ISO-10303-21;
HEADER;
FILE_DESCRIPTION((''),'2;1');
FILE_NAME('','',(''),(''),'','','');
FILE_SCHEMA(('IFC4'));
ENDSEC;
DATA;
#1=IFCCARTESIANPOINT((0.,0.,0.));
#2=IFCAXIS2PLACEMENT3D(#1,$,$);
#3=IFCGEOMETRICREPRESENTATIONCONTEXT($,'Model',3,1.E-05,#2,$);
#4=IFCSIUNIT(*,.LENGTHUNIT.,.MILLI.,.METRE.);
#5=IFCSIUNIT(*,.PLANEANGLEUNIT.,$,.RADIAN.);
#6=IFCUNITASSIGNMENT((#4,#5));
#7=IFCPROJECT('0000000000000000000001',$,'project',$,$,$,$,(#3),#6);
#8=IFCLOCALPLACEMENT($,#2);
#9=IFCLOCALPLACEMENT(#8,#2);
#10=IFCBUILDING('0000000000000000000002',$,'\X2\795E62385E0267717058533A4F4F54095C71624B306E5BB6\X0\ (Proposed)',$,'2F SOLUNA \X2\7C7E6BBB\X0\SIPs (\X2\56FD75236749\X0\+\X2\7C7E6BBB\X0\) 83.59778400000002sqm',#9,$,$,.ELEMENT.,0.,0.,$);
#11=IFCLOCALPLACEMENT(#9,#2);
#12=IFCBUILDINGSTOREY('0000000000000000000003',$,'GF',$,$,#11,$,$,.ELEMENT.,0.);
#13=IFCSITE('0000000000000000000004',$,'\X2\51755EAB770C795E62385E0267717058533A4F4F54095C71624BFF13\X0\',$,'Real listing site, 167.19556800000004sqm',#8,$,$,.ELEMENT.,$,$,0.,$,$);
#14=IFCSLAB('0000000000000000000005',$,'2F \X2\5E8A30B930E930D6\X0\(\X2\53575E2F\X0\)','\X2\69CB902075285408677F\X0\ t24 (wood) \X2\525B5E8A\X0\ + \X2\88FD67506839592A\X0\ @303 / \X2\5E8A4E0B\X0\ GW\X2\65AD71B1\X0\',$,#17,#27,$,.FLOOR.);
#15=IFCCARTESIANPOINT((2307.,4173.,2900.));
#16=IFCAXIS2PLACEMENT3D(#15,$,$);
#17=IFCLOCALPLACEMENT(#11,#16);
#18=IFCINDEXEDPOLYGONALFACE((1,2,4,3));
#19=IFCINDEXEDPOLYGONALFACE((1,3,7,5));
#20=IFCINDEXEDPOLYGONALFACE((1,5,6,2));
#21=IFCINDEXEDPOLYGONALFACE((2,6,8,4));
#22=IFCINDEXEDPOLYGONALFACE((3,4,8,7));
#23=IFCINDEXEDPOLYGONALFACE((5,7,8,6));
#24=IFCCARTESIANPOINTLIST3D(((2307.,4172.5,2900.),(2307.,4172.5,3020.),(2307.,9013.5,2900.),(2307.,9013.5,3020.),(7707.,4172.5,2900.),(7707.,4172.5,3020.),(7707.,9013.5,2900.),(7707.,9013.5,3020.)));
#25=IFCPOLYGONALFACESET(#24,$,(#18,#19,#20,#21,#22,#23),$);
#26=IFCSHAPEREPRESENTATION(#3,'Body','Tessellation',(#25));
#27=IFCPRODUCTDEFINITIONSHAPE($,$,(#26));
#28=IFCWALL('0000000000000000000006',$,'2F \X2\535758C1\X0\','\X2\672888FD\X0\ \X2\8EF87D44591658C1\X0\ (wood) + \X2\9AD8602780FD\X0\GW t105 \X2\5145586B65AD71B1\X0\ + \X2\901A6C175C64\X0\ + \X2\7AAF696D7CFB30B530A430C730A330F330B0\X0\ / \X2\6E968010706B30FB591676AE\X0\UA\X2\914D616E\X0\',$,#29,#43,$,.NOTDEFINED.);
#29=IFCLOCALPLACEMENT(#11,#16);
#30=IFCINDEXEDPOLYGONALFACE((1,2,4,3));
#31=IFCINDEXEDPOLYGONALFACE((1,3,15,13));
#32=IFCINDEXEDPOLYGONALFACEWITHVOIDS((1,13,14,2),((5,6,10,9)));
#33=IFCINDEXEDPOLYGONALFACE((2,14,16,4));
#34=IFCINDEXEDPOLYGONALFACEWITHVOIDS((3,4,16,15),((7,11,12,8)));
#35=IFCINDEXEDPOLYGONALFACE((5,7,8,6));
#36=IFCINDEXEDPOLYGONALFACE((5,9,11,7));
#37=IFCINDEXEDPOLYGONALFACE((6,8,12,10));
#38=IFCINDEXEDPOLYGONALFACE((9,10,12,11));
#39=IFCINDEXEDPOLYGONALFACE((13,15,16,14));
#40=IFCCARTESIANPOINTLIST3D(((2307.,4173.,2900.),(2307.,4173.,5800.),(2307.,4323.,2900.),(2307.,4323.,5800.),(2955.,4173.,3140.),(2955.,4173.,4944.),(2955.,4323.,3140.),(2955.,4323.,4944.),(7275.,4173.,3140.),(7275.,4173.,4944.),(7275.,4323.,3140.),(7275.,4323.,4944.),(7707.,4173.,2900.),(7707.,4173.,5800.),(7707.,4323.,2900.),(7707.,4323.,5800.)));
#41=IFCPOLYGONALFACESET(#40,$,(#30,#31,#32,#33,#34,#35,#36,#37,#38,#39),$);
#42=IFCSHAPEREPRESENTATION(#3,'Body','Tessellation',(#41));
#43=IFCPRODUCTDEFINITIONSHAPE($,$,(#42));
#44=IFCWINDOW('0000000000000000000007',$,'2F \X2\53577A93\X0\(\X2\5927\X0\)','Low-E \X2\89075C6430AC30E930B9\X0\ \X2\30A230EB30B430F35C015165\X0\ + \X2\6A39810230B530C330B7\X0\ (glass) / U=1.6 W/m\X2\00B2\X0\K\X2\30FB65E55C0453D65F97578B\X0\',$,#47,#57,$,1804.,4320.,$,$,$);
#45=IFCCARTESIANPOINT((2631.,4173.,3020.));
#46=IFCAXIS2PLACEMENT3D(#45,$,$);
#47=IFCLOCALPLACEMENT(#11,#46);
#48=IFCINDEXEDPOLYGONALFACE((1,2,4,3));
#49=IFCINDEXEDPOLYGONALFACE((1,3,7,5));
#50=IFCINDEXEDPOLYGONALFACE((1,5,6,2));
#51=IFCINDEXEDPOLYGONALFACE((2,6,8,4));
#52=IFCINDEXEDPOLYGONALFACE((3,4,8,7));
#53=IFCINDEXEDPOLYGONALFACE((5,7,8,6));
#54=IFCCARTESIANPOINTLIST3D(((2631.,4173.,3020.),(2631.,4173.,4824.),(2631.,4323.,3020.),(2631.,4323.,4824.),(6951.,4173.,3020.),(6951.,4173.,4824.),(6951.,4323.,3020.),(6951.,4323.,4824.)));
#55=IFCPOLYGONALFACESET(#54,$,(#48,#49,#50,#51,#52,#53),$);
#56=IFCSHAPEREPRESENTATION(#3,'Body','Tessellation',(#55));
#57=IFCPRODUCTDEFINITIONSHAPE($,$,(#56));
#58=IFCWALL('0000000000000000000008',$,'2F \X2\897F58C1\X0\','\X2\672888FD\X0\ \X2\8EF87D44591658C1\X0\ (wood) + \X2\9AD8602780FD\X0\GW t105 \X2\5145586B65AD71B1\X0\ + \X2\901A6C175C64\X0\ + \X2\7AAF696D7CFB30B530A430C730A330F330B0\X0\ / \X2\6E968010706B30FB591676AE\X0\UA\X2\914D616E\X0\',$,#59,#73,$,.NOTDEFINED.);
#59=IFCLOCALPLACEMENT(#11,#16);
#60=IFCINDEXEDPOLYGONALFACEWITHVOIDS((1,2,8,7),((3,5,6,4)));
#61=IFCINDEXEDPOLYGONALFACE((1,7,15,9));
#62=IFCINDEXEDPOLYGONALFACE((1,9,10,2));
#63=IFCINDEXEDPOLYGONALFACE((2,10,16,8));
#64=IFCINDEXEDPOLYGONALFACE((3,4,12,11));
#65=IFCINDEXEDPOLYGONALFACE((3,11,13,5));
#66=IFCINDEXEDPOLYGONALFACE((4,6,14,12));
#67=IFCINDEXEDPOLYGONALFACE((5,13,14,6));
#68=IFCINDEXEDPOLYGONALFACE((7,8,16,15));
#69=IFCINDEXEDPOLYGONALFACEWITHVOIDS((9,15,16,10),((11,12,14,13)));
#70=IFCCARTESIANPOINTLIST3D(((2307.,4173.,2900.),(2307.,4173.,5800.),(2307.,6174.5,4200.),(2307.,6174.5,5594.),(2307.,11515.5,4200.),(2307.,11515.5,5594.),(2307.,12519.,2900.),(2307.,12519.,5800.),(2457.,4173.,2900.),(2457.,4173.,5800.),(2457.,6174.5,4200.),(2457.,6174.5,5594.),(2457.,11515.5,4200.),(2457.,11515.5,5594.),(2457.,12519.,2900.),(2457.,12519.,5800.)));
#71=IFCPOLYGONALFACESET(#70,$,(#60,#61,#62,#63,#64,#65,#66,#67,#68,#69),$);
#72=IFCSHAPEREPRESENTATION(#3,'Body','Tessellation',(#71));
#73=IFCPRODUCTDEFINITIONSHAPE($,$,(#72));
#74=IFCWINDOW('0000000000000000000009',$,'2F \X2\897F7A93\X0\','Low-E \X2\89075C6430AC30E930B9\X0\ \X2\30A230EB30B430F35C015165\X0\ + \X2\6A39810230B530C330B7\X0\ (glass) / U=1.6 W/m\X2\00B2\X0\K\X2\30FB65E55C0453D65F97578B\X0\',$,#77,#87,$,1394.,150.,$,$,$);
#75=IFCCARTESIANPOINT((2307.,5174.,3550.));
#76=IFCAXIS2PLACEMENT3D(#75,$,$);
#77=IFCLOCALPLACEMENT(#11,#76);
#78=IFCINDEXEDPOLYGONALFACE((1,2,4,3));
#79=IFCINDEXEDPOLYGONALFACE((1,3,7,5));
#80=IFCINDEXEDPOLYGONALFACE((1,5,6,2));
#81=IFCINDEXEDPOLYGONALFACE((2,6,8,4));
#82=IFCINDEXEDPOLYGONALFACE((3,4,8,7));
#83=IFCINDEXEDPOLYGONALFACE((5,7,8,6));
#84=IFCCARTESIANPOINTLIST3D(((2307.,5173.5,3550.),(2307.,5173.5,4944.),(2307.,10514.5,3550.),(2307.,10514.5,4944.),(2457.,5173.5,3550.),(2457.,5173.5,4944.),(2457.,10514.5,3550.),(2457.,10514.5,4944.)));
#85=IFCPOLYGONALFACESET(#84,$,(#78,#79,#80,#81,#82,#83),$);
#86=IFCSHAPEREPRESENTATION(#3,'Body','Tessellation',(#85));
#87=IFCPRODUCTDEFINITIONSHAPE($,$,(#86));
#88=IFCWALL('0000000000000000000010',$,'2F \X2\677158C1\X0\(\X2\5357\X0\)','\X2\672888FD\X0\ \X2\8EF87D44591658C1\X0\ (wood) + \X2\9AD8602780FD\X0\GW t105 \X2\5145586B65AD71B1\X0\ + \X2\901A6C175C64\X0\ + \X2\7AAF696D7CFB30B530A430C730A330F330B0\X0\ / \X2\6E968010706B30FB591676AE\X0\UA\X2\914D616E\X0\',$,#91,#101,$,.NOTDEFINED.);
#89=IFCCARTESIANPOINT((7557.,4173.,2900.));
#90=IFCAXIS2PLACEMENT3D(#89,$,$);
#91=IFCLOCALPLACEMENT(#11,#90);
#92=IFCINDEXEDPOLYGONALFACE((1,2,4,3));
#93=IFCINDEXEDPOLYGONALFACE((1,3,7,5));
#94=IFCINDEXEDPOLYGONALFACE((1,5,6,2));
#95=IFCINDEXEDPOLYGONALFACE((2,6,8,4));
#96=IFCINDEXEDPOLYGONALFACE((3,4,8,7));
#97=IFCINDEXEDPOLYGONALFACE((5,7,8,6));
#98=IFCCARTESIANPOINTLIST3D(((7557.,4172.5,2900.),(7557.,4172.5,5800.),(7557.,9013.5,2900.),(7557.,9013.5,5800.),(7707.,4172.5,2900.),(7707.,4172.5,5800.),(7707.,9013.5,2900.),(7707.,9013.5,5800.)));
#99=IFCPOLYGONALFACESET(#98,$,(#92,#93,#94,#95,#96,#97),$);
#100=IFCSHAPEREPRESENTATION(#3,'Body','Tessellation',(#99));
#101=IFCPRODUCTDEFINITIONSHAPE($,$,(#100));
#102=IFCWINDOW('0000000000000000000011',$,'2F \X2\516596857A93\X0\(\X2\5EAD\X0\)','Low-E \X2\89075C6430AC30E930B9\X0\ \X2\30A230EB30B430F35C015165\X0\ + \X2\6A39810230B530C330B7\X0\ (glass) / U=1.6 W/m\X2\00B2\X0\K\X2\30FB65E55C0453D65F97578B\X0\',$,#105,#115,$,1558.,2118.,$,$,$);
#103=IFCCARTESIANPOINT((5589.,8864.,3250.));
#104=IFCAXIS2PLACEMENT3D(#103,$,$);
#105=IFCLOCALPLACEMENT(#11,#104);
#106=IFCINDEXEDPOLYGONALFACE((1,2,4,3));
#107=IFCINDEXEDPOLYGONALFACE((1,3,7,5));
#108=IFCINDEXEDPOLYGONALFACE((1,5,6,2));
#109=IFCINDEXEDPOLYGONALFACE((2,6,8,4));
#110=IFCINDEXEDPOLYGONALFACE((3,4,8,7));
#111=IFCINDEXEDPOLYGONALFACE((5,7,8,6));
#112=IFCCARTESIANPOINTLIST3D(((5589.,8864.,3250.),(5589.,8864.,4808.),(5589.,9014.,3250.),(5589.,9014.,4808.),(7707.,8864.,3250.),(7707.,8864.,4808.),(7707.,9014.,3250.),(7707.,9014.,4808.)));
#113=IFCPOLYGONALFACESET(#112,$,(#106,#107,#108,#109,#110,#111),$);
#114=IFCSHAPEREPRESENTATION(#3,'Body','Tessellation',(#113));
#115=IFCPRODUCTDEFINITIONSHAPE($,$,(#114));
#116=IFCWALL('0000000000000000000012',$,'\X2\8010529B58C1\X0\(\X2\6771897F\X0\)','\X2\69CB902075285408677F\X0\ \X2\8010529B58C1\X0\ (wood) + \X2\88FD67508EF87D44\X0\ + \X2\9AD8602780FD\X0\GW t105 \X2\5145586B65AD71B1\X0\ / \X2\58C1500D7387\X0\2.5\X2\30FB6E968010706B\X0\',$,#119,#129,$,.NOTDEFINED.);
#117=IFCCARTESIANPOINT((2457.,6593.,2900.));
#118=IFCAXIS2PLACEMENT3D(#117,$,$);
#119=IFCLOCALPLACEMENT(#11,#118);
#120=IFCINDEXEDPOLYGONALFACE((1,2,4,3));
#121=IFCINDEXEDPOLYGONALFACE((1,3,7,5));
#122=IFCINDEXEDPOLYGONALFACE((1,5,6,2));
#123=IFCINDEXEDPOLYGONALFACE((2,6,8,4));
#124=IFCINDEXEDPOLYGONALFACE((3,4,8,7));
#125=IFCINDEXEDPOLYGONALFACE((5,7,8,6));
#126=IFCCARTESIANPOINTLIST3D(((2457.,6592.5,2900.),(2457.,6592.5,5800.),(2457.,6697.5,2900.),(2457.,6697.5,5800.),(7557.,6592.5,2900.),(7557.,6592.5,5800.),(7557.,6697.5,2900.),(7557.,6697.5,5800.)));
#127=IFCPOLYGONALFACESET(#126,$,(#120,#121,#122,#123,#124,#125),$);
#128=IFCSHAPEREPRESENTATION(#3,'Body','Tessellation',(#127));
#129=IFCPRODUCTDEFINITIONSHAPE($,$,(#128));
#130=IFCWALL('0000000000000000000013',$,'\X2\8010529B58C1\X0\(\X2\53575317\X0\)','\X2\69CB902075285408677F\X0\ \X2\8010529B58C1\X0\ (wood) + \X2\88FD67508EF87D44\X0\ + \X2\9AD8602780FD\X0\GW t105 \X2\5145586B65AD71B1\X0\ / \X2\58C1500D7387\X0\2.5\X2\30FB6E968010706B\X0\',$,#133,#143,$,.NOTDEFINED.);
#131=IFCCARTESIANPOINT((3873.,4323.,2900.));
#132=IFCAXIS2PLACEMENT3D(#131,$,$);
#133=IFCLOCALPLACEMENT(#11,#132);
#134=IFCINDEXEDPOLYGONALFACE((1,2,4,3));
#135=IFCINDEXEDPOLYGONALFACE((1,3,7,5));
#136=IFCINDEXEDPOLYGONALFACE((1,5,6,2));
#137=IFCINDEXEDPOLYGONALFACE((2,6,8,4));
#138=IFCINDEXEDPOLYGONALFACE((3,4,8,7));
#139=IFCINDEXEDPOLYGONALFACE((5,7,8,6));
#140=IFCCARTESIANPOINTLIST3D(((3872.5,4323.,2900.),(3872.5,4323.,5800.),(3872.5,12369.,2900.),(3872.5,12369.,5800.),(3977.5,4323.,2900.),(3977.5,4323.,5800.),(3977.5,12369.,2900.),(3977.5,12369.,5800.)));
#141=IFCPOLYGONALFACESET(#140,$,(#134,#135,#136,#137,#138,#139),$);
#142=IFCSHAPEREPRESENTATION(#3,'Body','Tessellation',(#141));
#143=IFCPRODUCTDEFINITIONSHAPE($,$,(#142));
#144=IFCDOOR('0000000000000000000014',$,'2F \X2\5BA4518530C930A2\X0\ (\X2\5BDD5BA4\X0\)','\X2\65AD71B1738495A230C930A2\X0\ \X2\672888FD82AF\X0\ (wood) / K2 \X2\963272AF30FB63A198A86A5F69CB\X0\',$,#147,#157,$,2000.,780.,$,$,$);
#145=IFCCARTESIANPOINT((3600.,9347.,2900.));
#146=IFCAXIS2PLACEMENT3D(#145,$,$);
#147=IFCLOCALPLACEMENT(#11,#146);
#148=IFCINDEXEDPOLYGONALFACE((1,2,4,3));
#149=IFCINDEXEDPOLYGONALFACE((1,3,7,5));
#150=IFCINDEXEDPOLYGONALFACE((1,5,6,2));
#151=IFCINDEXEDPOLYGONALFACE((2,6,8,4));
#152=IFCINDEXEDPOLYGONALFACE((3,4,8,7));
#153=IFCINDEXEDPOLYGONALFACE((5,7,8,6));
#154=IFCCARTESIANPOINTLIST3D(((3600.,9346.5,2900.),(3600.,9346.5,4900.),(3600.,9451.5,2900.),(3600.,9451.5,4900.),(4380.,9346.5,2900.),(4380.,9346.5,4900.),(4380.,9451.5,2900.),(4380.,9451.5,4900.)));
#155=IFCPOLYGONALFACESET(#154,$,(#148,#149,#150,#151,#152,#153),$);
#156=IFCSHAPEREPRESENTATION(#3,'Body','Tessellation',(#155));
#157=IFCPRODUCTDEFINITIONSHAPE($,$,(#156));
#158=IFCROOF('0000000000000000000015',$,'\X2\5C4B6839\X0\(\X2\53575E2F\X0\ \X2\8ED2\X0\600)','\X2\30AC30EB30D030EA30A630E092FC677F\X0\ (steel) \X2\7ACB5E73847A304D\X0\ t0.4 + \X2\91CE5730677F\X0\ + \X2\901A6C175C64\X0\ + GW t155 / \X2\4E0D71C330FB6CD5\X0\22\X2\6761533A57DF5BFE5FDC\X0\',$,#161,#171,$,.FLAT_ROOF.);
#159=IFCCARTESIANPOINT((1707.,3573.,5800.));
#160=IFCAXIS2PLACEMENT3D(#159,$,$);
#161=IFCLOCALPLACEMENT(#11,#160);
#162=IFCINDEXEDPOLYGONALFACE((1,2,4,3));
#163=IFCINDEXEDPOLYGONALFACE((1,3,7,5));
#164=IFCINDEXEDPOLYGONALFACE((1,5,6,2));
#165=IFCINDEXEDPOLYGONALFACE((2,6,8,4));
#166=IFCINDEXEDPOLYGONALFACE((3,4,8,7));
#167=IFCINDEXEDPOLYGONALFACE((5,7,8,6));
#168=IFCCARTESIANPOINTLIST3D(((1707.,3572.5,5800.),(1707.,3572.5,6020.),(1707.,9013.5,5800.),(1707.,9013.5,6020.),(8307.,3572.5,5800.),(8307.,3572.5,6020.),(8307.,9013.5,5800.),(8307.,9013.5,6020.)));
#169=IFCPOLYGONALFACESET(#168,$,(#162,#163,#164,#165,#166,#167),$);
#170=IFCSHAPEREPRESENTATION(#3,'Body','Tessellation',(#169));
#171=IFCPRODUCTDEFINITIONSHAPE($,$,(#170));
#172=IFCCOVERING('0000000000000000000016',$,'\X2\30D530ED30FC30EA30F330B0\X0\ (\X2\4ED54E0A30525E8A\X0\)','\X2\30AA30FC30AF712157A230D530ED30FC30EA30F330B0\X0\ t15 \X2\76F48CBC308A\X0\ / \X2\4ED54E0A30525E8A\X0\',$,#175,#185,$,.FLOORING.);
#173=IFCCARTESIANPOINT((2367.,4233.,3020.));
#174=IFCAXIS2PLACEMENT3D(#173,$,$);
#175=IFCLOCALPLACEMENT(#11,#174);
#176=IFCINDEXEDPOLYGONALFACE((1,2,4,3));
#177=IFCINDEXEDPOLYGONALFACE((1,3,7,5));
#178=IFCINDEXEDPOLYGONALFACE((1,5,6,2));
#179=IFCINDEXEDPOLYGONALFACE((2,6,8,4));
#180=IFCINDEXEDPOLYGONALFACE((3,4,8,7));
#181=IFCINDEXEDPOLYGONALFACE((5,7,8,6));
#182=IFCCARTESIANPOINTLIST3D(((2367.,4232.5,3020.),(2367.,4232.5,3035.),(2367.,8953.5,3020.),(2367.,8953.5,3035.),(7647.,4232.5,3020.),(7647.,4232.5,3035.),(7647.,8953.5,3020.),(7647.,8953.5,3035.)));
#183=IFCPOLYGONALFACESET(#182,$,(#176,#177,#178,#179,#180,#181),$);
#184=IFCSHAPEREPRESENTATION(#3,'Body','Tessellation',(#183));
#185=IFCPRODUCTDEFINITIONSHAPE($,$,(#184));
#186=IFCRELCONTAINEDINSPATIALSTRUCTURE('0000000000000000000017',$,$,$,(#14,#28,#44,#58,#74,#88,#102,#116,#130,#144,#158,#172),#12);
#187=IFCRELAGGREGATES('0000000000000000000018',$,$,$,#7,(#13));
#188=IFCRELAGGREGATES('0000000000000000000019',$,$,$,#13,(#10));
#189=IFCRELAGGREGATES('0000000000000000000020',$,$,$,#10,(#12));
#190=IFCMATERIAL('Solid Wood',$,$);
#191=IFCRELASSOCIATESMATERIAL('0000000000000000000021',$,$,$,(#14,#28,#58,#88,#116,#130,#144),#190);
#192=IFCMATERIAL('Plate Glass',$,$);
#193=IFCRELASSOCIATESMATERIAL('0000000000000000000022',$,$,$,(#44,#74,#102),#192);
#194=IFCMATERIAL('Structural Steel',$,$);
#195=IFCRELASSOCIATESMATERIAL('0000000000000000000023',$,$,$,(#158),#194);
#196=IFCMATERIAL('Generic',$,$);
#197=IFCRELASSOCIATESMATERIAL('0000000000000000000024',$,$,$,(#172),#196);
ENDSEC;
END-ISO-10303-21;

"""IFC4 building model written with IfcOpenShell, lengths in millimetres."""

from ifc_helpers import new_model, si_unit, frame, frame_2d, origin, place, context, project, spatial, rectangle, extrude, material, element, fill, save


model = new_model("IFC4")

# Units and contexts
model_context = context("Model", 3, precision=1e-05, world=origin())
ifc_project = project(units=[si_unit("LENGTHUNIT", "METRE", prefix="MILLI"), si_unit("PLANEANGLEUNIT", "RADIAN")], contexts=[model_context])

# Site, building, storey
site_placement = place(None, origin())
site = spatial("IfcSite", under=ifc_project, at=site_placement, Name="兵庫県神戸市東灘区住吉山手３", ObjectType="Real listing site, 167.19556800000004sqm", CompositionType="ELEMENT", RefElevation=0.0)
building_placement = place(site_placement, origin())
building = spatial("IfcBuilding", under=site, at=building_placement, Name="神戸市東灘区住吉山手の家 (Proposed)", ObjectType="2F SOLUNA 籾殻SIPs (国産杉+籾殻) 83.59778400000002sqm", CompositionType="ELEMENT", ElevationOfRefHeight=0.0, ElevationOfTerrain=0.0)
storey_placement = place(building_placement, origin())
storey = spatial("IfcBuildingStorey", under=building, at=storey_placement, Name="GF", CompositionType="ELEMENT", Elevation=0.0)

# Slab
ifc_material_1 = material(Name="Solid Wood")
slab_placement = place(storey_placement, frame((2307.0, 4173.0, 2900.0)))
element("IfcSlab", 1, at=slab_placement, inside=storey, material=ifc_material_1, Name="2F 床スラブ(南帯)", Description="構造用合板 t24 (wood) 剛床 + 製材根太 @303 / 床下 GW断熱", PredefinedType="FLOOR", context=model_context, shape_type="SweptSolid", body=[
    extrude(rectangle(XDim=5400.0, YDim=4841.0, at=frame_2d((2700.0, 2420.0))), frame((2307.0, 4173.0, 2900.0)), (0.0, 0.0, 1.0), 120.0),
])

# Walls, openings, windows
wall_1_placement = place(storey_placement, frame((2307.0, 4173.0, 2900.0)))
wall_1 = element("IfcWall", 2, at=wall_1_placement, inside=storey, material=ifc_material_1, Name="2F 南壁", Description="木製 軸組外壁 (wood) + 高性能GW t105 充填断熱 + 通気層 + 窯業系サイディング / 準耐火・外皮UA配慮", PredefinedType="NOTDEFINED", context=model_context, shape_type="SweptSolid", body=[
    extrude(rectangle(XDim=5400.0, YDim=150.0, at=frame_2d((2700.0, 75.0))), frame((2307.0, 4173.0, 2900.0)), (0.0, 0.0, 1.0), 2900.0),
])
opening_1_placement = place(storey_placement, frame((2631.0, 4173.0, 3020.0)))
opening_1 = element("IfcOpeningElement", 3, at=opening_1_placement, cuts=wall_1, PredefinedType="NOTDEFINED", context=model_context, shape_type="SweptSolid", body=[
    extrude(rectangle(XDim=4320.0, YDim=150.0, at=frame_2d((2160.0, 75.0))), frame((2631.0, 4173.0, 3020.0)), (0.0, 0.0, 1.0), 1804.0),
])
ifc_material_2 = material(Name="Plate Glass")
window_1_placement = place(storey_placement, frame((2631.0, 4173.0, 3020.0)))
window_1 = element("IfcWindow", 4, at=window_1_placement, inside=storey, material=ifc_material_2, Name="2F 南窓(大)", Description="Low-E 複層ガラス アルゴン封入 + 樹脂サッシ (glass) / U=1.6 W/m²K・日射取得型", OverallHeight=1804.0, OverallWidth=4320.0, context=model_context, shape_type="SweptSolid", body=[
    extrude(rectangle(XDim=4320.0, YDim=150.0, at=frame_2d((2160.0, 75.0))), frame((2631.0, 4173.0, 3020.0)), (0.0, 0.0, 1.0), 1804.0),
])
fill(opening_1, window_1)
wall_2_placement = place(storey_placement, frame((2307.0, 4173.0, 2900.0)))
wall_2 = element("IfcWall", 5, at=wall_2_placement, inside=storey, material=ifc_material_1, Name="2F 西壁", Description="木製 軸組外壁 (wood) + 高性能GW t105 充填断熱 + 通気層 + 窯業系サイディング / 準耐火・外皮UA配慮", PredefinedType="NOTDEFINED", context=model_context, shape_type="SweptSolid", body=[
    extrude(rectangle(XDim=150.0, YDim=8346.0, at=frame_2d((75.0, 4173.0))), frame((2307.0, 4173.0, 2900.0)), (0.0, 0.0, 1.0), 2900.0),
])
opening_2_placement = place(storey_placement, frame((2307.0, 5174.0, 3550.0)))
opening_2 = element("IfcOpeningElement", 6, at=opening_2_placement, cuts=wall_2, PredefinedType="NOTDEFINED", context=model_context, shape_type="SweptSolid", body=[
    extrude(rectangle(XDim=150.0, YDim=5341.0, at=frame_2d((75.0, 2670.0))), frame((2307.0, 5174.0, 3550.0)), (0.0, 0.0, 1.0), 1394.0),
])
window_2_placement = place(storey_placement, frame((2307.0, 5174.0, 3550.0)))
window_2 = element("IfcWindow", 7, at=window_2_placement, inside=storey, material=ifc_material_2, Name="2F 西窓", Description="Low-E 複層ガラス アルゴン封入 + 樹脂サッシ (glass) / U=1.6 W/m²K・日射取得型", OverallHeight=1394.0, OverallWidth=150.0, context=model_context, shape_type="SweptSolid", body=[
    extrude(rectangle(XDim=150.0, YDim=5341.0, at=frame_2d((75.0, 2670.0))), frame((2307.0, 5174.0, 3550.0)), (0.0, 0.0, 1.0), 1394.0),
])
fill(opening_2, window_2)
wall_3_placement = place(storey_placement, frame((7557.0, 4173.0, 2900.0)))
wall_3 = element("IfcWall", 8, at=wall_3_placement, inside=storey, material=ifc_material_1, Name="2F 東壁(南)", Description="木製 軸組外壁 (wood) + 高性能GW t105 充填断熱 + 通気層 + 窯業系サイディング / 準耐火・外皮UA配慮", PredefinedType="NOTDEFINED", context=model_context, shape_type="SweptSolid", body=[
    extrude(rectangle(XDim=150.0, YDim=4841.0, at=frame_2d((75.0, 2420.0))), frame((7557.0, 4173.0, 2900.0)), (0.0, 0.0, 1.0), 2900.0),
])
opening_3_placement = place(storey_placement, frame((5589.0, 8864.0, 3250.0)))
opening_3 = element("IfcOpeningElement", 9, at=opening_3_placement, cuts=wall_3, PredefinedType="NOTDEFINED", context=model_context, shape_type="SweptSolid", body=[
    extrude(rectangle(XDim=2118.0, YDim=150.0, at=frame_2d((1059.0, 75.0))), frame((5589.0, 8864.0, 3250.0)), (0.0, 0.0, 1.0), 1558.0),
])
window_3_placement = place(storey_placement, frame((5589.0, 8864.0, 3250.0)))
window_3 = element("IfcWindow", 10, at=window_3_placement, inside=storey, material=ifc_material_2, Name="2F 入隅窓(庭)", Description="Low-E 複層ガラス アルゴン封入 + 樹脂サッシ (glass) / U=1.6 W/m²K・日射取得型", OverallHeight=1558.0, OverallWidth=2118.0, context=model_context, shape_type="SweptSolid", body=[
    extrude(rectangle(XDim=2118.0, YDim=150.0, at=frame_2d((1059.0, 75.0))), frame((5589.0, 8864.0, 3250.0)), (0.0, 0.0, 1.0), 1558.0),
])
fill(opening_3, window_3)

# Wall
wall_4_placement = place(storey_placement, frame((2457.0, 6593.0, 2900.0)))
element("IfcWall", 11, at=wall_4_placement, inside=storey, material=ifc_material_1, Name="耐力壁(東西)", Description="構造用合板 耐力壁 (wood) + 製材軸組 + 高性能GW t105 充填断熱 / 壁倍率2.5・準耐火", PredefinedType="NOTDEFINED", context=model_context, shape_type="SweptSolid", body=[
    extrude(rectangle(XDim=5100.0, YDim=105.0, at=frame_2d((2550.0, 52.0))), frame((2457.0, 6593.0, 2900.0)), (0.0, 0.0, 1.0), 2900.0),
])

# Wall, opening, door
wall_5_placement = place(storey_placement, frame((3873.0, 4323.0, 2900.0)))
wall_5 = element("IfcWall", 12, at=wall_5_placement, inside=storey, material=ifc_material_1, Name="耐力壁(南北)", Description="構造用合板 耐力壁 (wood) + 製材軸組 + 高性能GW t105 充填断熱 / 壁倍率2.5・準耐火", PredefinedType="NOTDEFINED", context=model_context, shape_type="SweptSolid", body=[
    extrude(rectangle(XDim=105.0, YDim=8046.0, at=frame_2d((52.0, 4023.0))), frame((3873.0, 4323.0, 2900.0)), (0.0, 0.0, 1.0), 2900.0),
])
opening_4_placement = place(storey_placement, frame((3600.0, 9347.0, 2900.0)))
opening_4 = element("IfcOpeningElement", 13, at=opening_4_placement, cuts=wall_5, PredefinedType="NOTDEFINED", context=model_context, shape_type="SweptSolid", body=[
    extrude(rectangle(XDim=780.0, YDim=105.0, at=frame_2d((390.0, 52.0))), frame((3600.0, 9347.0, 2900.0)), (0.0, 0.0, 1.0), 2000.0),
])
door_placement = place(storey_placement, frame((3600.0, 9347.0, 2900.0)))
door = element("IfcDoor", 14, at=door_placement, inside=storey, material=ifc_material_1, Name="2F 室内ドア (寝室)", Description="断熱玄関ドア 木製芯 (wood) / K2 防犯・採風機構", OverallHeight=2000.0, OverallWidth=780.0, context=model_context, shape_type="SweptSolid", body=[
    extrude(rectangle(XDim=780.0, YDim=105.0, at=frame_2d((390.0, 52.0))), frame((3600.0, 9347.0, 2900.0)), (0.0, 0.0, 1.0), 2000.0),
])
fill(opening_4, door)

# Roof
ifc_material_3 = material(Name="Structural Steel")
for number, where, name in (
    (15, (1707.0, 3573.0, 5800.0), "屋根(南帯 軒600)"),
):
    element("IfcRoof", number, at=place(storey_placement, frame(where)), inside=storey, material=ifc_material_3, Name=name, Description="ガルバリウム鋼板 (steel) 立平葺き t0.4 + 野地板 + 通気層 + GW t155 / 不燃・法22条区域対応", PredefinedType="FLAT_ROOF", context=model_context, shape_type="SweptSolid", body=[
        extrude(rectangle(XDim=6600.0, YDim=5441.0, at=frame_2d((3300.0, 2720.0))), frame((1707.0, 3573.0, 5800.0)), (0.0, 0.0, 1.0), 220.0),
    ])

# Covering
ifc_material_4 = material(Name="Generic")
covering_placement = place(storey_placement, frame((2367.0, 4233.0, 3020.0)))
element("IfcCovering", 16, at=covering_placement, inside=storey, material=ifc_material_4, Name="フローリング (仕上げ床)", Description="オーク無垢フローリング t15 直貼り / 仕上げ床", PredefinedType="FLOORING", context=model_context, shape_type="SweptSolid", body=[
    extrude(rectangle(XDim=5280.0, YDim=4721.0, at=frame_2d((2640.0, 2360.0))), frame((2367.0, 4233.0, 3020.0)), (0.0, 0.0, 1.0), 15.0),
])

save(model, "model.ifc")
